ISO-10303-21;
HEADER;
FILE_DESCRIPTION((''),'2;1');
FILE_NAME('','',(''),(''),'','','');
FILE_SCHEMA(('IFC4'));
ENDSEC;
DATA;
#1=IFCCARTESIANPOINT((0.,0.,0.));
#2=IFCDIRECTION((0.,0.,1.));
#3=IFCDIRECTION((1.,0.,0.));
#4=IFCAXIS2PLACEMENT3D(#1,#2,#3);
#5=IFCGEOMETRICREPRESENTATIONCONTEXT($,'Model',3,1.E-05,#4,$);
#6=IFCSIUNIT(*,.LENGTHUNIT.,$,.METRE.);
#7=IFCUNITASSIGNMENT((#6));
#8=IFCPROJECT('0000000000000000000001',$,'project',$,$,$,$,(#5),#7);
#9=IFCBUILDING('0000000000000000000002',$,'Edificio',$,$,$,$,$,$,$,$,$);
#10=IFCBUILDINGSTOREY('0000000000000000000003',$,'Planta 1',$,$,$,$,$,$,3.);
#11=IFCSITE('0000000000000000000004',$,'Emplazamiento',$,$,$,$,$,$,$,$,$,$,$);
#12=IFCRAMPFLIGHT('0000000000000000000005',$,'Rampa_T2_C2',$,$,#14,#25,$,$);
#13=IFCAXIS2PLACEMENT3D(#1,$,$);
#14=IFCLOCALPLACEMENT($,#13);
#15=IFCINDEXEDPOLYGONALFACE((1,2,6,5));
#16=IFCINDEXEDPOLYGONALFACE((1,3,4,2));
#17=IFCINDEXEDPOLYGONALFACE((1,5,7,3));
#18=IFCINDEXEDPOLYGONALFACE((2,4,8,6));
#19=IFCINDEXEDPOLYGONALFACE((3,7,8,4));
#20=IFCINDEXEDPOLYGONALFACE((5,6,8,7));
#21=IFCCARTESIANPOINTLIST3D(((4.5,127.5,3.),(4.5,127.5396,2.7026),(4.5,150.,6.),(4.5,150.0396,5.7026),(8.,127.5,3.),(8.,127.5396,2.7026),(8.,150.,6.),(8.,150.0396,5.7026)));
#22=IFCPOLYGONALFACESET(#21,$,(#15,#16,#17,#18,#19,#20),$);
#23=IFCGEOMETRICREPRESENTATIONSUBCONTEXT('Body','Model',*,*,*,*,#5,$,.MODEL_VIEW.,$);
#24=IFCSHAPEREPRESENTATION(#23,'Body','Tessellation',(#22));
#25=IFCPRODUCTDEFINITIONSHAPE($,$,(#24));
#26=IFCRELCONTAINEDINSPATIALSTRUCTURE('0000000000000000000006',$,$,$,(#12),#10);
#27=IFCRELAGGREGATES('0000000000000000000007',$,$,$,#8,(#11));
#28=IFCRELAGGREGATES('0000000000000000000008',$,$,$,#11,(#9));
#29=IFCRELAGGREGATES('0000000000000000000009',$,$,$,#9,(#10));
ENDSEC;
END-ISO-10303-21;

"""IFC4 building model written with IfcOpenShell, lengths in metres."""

from ifc_helpers import new_model, si_unit, frame, origin_with_axes, origin_2d, place, context, subcontext, project, spatial, rectangle, extrude, element, save


model = new_model("IFC4")

# Units and contexts
model_context = context("Model", 3, precision=1e-05, world=origin_with_axes())
body_context = subcontext(model_context, "Body", "Model", "MODEL_VIEW")
ifc_project = project(units=[si_unit("LENGTHUNIT", "METRE")], contexts=[model_context])

# Site, building, storey
site = spatial("IfcSite", under=ifc_project, Name="Emplazamiento")
building = spatial("IfcBuilding", under=site, Name="Edificio")
storey = spatial("IfcBuildingStorey", under=building, Name="Planta 1", Elevation=3.0)

# Ramp flight
for number, where, z_axis, x_axis, name in (
    (1, (6.25, 138.7896, 4.2026), (0.0, -0.132164, 0.991228), (0.0, 0.991228, 0.132164), "Rampa_T2_C2"),
):
    element("IfcRampFlight", number, at=place(None, frame(where, z_axis=z_axis, x_axis=x_axis)), inside=storey, Name=name, context=body_context, shape_type="SweptSolid", body=[
        extrude(rectangle(XDim=22.6991, YDim=3.5, at=origin_2d()), origin_with_axes(), (0.0, 0.0, 1.0), 0.3),
    ])

save(model, "model.ifc")
